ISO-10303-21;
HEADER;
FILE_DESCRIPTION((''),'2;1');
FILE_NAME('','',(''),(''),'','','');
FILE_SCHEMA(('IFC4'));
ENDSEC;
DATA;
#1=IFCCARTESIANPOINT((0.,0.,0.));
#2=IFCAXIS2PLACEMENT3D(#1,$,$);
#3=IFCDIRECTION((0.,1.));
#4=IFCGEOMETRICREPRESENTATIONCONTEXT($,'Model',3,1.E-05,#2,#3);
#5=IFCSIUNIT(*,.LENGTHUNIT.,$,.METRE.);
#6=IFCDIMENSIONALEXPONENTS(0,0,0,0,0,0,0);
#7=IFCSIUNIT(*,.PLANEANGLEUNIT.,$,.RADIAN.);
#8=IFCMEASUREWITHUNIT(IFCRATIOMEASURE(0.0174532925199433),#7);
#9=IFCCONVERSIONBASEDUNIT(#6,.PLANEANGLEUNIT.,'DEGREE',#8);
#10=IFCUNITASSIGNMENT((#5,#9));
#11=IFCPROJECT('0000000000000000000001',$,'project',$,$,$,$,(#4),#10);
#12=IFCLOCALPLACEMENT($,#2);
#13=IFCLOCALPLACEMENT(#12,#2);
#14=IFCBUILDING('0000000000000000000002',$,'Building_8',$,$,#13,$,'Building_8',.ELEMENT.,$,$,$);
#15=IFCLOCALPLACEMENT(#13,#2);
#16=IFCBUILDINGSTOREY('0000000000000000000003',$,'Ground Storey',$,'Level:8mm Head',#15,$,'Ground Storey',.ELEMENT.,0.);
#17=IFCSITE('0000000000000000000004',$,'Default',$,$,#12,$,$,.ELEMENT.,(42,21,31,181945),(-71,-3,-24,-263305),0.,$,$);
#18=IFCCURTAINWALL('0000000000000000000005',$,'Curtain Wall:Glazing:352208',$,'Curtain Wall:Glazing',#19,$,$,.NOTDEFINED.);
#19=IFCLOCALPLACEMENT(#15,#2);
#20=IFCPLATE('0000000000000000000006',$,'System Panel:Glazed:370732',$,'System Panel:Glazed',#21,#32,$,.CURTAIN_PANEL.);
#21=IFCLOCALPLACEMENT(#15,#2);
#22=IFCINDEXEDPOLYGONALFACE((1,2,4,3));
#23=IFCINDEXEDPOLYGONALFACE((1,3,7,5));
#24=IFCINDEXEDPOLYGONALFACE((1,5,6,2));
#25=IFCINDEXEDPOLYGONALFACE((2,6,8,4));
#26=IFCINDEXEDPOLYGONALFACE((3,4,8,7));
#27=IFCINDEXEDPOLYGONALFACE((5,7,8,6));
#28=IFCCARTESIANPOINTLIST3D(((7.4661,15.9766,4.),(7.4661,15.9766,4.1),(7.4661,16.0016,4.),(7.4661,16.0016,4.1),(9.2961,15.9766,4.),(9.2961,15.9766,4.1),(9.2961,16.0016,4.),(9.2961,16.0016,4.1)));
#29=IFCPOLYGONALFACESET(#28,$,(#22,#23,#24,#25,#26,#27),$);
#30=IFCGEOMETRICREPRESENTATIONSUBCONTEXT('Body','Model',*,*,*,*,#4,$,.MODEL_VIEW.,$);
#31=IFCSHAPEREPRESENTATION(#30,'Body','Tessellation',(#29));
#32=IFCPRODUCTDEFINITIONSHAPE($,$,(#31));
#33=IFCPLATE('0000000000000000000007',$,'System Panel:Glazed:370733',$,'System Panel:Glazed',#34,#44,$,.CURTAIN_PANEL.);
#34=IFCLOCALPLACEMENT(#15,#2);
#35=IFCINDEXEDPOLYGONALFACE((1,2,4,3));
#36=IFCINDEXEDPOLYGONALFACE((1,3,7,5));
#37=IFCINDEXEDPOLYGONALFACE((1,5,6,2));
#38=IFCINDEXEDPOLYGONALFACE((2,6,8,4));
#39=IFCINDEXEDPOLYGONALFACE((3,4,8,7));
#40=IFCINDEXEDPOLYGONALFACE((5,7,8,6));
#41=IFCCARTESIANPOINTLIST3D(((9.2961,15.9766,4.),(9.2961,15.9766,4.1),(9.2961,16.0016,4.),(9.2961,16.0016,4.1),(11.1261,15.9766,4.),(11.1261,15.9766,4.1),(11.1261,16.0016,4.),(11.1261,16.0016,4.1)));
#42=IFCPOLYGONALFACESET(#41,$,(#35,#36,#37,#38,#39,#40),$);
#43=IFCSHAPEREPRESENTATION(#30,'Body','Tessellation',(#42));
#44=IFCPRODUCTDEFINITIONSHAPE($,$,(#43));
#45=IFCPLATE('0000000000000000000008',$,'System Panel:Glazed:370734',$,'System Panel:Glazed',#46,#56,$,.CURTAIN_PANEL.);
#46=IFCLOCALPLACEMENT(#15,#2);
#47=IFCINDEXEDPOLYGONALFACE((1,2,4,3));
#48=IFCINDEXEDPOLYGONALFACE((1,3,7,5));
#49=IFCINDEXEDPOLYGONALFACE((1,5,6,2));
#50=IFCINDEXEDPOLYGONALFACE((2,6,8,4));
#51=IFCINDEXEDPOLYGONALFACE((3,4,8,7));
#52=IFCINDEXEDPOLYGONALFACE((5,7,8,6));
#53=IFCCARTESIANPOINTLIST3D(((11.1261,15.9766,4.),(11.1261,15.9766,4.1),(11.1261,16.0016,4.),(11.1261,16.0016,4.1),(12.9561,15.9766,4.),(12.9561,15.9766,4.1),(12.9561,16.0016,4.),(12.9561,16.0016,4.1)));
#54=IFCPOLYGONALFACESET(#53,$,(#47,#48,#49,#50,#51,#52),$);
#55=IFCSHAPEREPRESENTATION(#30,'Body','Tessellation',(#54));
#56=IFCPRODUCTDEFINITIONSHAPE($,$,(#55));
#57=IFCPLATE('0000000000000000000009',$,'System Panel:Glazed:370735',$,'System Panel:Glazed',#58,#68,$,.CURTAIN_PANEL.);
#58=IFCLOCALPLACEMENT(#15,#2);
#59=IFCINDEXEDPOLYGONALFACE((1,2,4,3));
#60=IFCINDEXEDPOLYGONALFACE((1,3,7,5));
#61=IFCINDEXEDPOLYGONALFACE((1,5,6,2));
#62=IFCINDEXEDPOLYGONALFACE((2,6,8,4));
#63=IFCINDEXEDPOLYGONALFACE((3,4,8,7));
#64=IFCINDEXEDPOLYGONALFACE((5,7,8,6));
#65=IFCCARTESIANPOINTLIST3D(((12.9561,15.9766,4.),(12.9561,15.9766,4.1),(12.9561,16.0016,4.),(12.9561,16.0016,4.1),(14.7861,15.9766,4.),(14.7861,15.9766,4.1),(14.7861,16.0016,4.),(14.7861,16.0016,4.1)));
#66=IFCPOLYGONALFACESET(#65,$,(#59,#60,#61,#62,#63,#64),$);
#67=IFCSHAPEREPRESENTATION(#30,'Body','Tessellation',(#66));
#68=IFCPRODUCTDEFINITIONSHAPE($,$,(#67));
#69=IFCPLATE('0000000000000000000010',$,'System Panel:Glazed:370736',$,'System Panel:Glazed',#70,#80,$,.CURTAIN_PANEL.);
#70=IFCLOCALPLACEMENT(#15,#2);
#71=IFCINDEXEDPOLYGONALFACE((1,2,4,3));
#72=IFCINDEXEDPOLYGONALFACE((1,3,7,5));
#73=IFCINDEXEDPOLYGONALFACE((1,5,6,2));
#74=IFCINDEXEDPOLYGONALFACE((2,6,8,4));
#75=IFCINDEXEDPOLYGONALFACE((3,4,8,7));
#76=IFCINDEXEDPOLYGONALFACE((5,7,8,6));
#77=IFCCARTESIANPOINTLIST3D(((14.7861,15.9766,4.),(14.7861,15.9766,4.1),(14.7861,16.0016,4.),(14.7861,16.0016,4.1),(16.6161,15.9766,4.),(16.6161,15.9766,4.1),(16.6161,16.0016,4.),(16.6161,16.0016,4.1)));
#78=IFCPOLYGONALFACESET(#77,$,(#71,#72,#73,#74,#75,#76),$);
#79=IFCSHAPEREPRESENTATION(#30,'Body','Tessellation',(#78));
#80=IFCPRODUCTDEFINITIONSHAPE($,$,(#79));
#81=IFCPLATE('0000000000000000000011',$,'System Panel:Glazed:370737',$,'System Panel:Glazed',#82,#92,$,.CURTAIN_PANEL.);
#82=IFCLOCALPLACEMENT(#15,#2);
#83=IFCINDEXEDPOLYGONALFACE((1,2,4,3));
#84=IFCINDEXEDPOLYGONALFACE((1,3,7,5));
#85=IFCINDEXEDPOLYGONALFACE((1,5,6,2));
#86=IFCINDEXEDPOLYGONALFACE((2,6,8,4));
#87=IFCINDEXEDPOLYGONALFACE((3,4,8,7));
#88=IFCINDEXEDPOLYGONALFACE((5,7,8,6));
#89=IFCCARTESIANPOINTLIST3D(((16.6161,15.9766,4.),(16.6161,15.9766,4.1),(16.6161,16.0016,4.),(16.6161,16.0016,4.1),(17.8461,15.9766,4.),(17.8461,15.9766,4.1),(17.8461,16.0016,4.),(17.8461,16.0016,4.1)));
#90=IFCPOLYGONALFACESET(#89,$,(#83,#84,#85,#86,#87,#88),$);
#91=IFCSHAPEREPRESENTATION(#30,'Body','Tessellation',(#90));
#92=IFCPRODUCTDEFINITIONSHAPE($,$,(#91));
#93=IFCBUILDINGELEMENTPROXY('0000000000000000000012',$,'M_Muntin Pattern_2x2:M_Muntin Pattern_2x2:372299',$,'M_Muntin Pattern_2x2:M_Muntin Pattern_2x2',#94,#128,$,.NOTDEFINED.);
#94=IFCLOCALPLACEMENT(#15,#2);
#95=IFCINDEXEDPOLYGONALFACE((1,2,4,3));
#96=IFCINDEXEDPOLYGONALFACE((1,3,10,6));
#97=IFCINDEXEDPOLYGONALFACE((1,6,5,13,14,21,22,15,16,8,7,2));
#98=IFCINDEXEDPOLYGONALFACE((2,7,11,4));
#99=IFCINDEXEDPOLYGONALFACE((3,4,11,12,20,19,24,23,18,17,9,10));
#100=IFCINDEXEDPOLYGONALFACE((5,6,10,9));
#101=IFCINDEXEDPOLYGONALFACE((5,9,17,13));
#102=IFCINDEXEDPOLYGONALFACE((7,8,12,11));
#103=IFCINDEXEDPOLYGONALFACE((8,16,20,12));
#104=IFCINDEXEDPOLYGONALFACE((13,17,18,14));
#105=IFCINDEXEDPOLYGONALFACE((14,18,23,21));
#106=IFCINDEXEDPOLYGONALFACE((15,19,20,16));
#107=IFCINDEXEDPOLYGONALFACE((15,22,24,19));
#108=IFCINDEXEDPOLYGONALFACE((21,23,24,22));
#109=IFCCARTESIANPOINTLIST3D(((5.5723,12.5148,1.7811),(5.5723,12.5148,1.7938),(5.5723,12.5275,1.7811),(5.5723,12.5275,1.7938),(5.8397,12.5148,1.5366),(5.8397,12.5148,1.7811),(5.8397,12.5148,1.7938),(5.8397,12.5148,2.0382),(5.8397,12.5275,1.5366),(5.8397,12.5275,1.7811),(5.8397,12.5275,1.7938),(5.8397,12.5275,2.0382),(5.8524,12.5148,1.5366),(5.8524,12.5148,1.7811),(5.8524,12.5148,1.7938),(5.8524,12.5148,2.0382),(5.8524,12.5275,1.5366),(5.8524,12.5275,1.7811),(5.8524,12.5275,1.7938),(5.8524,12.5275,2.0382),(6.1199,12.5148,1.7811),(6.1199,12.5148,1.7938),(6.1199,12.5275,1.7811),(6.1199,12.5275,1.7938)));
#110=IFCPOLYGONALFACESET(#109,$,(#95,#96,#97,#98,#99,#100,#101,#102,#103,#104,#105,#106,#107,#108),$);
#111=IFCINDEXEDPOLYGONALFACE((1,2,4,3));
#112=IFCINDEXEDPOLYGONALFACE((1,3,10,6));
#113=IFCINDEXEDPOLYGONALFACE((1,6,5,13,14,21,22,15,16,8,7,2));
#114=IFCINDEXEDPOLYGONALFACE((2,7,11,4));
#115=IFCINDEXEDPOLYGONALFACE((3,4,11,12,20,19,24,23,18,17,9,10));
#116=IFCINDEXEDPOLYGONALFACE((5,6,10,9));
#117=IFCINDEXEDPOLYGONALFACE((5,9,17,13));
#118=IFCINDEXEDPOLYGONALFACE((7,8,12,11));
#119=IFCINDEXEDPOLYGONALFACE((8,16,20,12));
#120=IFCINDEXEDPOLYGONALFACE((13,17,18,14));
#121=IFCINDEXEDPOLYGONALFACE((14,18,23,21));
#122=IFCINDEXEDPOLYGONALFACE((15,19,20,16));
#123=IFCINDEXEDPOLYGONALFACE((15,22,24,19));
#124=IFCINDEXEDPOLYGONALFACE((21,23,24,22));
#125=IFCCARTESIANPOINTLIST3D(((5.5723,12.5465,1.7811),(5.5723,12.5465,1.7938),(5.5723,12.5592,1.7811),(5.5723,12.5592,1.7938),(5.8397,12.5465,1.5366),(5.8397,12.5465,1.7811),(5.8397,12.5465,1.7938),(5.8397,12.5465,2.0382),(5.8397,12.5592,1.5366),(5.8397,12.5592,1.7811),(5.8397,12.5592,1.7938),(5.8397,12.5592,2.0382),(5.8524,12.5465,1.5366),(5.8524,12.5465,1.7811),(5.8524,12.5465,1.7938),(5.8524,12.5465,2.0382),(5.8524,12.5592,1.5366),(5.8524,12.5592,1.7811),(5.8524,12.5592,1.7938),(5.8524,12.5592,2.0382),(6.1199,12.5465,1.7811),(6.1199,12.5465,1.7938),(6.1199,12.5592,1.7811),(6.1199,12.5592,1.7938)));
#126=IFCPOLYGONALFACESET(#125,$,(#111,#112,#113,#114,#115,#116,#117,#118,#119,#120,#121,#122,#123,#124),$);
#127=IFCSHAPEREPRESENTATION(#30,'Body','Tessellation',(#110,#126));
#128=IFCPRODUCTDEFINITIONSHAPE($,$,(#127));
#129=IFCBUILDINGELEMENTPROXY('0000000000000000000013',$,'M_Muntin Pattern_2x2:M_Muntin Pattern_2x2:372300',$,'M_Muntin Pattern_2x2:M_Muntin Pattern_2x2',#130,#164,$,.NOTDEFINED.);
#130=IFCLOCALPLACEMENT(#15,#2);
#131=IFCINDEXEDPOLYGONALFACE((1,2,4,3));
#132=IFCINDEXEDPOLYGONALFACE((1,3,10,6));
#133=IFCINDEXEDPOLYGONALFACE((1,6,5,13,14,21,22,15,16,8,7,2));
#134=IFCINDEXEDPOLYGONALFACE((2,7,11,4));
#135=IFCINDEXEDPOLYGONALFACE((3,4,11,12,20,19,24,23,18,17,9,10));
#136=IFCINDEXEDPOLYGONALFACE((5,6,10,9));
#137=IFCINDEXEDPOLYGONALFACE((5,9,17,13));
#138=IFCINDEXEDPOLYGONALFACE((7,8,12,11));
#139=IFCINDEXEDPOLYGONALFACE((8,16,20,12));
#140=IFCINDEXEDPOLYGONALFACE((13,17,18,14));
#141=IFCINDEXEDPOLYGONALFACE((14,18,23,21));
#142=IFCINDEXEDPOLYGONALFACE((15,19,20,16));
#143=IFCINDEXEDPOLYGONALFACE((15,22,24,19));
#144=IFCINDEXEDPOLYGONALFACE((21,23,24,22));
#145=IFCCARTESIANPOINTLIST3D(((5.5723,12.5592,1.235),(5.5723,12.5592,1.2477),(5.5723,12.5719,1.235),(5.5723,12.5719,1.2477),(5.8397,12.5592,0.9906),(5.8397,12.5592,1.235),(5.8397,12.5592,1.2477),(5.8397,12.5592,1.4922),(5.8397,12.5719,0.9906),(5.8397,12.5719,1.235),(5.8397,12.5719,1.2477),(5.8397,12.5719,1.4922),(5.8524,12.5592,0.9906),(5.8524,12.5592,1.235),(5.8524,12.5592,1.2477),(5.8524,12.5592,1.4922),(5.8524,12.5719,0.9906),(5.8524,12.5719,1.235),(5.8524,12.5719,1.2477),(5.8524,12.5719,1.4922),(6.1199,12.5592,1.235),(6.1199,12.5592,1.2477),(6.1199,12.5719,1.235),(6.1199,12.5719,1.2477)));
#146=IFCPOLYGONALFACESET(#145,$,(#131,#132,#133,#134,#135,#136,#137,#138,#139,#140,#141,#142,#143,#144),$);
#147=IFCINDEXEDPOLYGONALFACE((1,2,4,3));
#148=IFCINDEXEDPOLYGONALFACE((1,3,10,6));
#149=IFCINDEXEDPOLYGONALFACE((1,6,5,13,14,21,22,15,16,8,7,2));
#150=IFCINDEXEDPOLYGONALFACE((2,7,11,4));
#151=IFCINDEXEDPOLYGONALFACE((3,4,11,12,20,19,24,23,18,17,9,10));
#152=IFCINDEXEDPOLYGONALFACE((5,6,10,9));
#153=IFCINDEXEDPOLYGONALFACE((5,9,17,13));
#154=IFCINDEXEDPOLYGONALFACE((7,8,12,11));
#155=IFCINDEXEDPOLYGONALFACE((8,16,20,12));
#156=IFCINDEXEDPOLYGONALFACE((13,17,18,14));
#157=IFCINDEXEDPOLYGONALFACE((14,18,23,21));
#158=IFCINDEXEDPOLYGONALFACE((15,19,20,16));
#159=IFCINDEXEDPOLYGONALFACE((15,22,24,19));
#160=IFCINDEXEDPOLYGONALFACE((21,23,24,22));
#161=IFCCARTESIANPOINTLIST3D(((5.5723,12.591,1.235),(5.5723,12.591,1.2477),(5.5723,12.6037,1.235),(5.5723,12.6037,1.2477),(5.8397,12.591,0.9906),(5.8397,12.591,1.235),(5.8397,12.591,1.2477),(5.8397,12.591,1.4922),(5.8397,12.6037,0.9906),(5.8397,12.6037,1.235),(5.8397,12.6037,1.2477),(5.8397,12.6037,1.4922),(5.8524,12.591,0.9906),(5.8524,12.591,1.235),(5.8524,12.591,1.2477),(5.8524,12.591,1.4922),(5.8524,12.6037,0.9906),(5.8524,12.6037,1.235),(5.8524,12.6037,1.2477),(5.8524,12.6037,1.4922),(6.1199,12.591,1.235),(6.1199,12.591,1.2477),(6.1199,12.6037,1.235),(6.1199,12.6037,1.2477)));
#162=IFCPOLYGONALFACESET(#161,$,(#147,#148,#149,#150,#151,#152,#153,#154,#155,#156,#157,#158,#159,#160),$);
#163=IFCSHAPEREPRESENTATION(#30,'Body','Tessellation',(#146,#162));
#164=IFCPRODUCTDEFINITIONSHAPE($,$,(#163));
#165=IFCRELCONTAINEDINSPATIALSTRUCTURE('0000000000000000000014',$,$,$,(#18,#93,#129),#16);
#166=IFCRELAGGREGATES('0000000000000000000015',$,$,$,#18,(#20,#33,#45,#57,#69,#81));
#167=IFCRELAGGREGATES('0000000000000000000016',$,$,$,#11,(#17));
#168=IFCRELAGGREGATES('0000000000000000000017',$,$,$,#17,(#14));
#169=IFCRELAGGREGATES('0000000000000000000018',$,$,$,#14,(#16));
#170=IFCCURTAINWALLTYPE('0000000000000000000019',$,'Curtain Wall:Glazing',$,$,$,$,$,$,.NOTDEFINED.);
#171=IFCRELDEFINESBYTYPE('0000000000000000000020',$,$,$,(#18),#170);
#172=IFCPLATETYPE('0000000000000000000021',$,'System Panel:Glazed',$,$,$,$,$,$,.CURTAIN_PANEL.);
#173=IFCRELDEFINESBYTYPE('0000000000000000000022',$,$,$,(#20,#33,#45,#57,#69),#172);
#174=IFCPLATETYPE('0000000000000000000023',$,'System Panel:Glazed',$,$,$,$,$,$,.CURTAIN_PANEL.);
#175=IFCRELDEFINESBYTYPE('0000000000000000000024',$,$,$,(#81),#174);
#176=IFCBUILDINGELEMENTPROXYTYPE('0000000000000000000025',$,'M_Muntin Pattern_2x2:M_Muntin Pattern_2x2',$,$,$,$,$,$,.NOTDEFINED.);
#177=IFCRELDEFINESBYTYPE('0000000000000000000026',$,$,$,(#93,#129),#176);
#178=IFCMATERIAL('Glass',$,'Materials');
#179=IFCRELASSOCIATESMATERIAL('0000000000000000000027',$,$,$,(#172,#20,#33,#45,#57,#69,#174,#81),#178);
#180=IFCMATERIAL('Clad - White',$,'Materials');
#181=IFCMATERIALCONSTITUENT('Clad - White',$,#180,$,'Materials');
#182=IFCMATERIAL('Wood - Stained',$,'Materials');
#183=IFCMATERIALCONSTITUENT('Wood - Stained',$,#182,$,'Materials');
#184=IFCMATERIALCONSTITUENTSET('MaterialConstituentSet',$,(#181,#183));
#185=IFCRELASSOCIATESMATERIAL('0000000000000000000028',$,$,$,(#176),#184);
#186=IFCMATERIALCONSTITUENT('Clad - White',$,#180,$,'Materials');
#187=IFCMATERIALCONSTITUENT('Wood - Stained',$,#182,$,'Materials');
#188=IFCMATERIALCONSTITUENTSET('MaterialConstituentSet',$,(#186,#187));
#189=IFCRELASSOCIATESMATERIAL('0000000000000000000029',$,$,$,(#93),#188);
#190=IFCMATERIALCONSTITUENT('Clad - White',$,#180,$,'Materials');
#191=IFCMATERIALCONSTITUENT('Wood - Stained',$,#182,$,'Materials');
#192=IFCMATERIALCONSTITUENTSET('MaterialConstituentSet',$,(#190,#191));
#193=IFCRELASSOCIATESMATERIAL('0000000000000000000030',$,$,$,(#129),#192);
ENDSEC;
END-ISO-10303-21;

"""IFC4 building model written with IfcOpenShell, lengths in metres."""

from ifc_helpers import new_model, entity, si_unit, converted_unit, direction, frame, origin, place, context, subcontext, project, spatial, indexed_curve, outline, extrude, source, transform, mapped, material, constituent, constituent_set, type_object, type_shapes, element, aggregate, save


model = new_model("IFC4")

# Units and contexts
model_context = context("Model", 3, precision=1e-05, world=origin(), true_north=direction((0.0, 1.0)))
body_context = subcontext(model_context, "Body", "Model", "MODEL_VIEW")
ifc_project = project(units=[si_unit("LENGTHUNIT", "METRE"), converted_unit("PLANEANGLEUNIT", "DEGREE", entity("IfcRatioMeasure", 0.0174532925199433), si_unit("PLANEANGLEUNIT", "RADIAN"), dimensions=[0, 0, 0, 0, 0, 0, 0])], contexts=[model_context])

# Site, building, storey
site_placement = place(None, origin())
site = spatial("IfcSite", under=ifc_project, at=site_placement, Name="Default", CompositionType="ELEMENT", RefLatitude=(42, 21, 31, 181945), RefLongitude=(-71, -3, -24, -263305), RefElevation=0.0)
building_placement = place(site_placement, origin())
building = spatial("IfcBuilding", under=site, at=building_placement, Name="Building_8", LongName="Building_8", CompositionType="ELEMENT")
storey_placement = place(building_placement, origin())
storey = spatial("IfcBuildingStorey", under=building, at=storey_placement, Name="Ground Storey", ObjectType="Level:8mm Head", LongName="Ground Storey", CompositionType="ELEMENT", Elevation=0.0)

# Curtain wall, plates
curtain_wall_type = type_object("IfcCurtainWallType", Name="Curtain Wall:Glazing", PredefinedType="NOTDEFINED")
curtain_wall_placement = place(storey_placement, origin())
curtain_wall = element("IfcCurtainWall", 1, at=curtain_wall_placement, inside=storey, type_object=curtain_wall_type, Name="Curtain Wall:Glazing:352208", ObjectType="Curtain Wall:Glazing", PredefinedType="NOTDEFINED")
ifc_material_1 = material(Name="Glass", Category="Materials")
plate_type_1 = type_object("IfcPlateType", Name="System Panel:Glazed", PredefinedType="CURTAIN_PANEL", material=ifc_material_1)
shared_shape_1 = source(origin(), body_context, "Body", "SweptSolid", [
    extrude(outline(indexed_curve([(-0.0125, -0.915), (0.0125, -0.915), (0.0125, 0.915), (-0.0125, 0.915), (-0.0125, -0.915)], self_intersect=False)), frame((0.0, 0.037, 0.0), z_axis=(0.0, 0.0, 1.0), x_axis=(0.0, 1.0, 0.0)), (0.0, 0.0, 1.0), 0.1),
])
type_shapes(plate_type_1, [shared_shape_1])
plate_1_placement = place(curtain_wall_placement, frame((8.3811, 15.9521, 4.0)))
plate_1 = element("IfcPlate", 2, at=plate_1_placement, type_object=plate_type_1, material=ifc_material_1, Name="System Panel:Glazed:370732", ObjectType="System Panel:Glazed", PredefinedType="CURTAIN_PANEL", context=body_context, shape_type="MappedRepresentation", body=[
    mapped(shared_shape_1, transform((0.0, 0.0, 0.0), scale=1.0)),
])
plate_2_placement = place(curtain_wall_placement, frame((10.2111, 15.9521, 4.0)))
plate_2 = element("IfcPlate", 3, at=plate_2_placement, type_object=plate_type_1, material=ifc_material_1, Name="System Panel:Glazed:370733", ObjectType="System Panel:Glazed", PredefinedType="CURTAIN_PANEL", context=body_context, shape_type="MappedRepresentation", body=[
    mapped(shared_shape_1, transform((0.0, 0.0, 0.0), scale=1.0)),
])
plate_3_placement = place(curtain_wall_placement, frame((12.0411, 15.9521, 4.0)))
plate_3 = element("IfcPlate", 4, at=plate_3_placement, type_object=plate_type_1, material=ifc_material_1, Name="System Panel:Glazed:370734", ObjectType="System Panel:Glazed", PredefinedType="CURTAIN_PANEL", context=body_context, shape_type="MappedRepresentation", body=[
    mapped(shared_shape_1, transform((0.0, 0.0, 0.0), scale=1.0)),
])
plate_4_placement = place(curtain_wall_placement, frame((13.8711, 15.9521, 4.0)))
plate_4 = element("IfcPlate", 5, at=plate_4_placement, type_object=plate_type_1, material=ifc_material_1, Name="System Panel:Glazed:370735", ObjectType="System Panel:Glazed", PredefinedType="CURTAIN_PANEL", context=body_context, shape_type="MappedRepresentation", body=[
    mapped(shared_shape_1, transform((0.0, 0.0, 0.0), scale=1.0)),
])
plate_5_placement = place(curtain_wall_placement, frame((15.7011, 15.9521, 4.0)))
plate_5 = element("IfcPlate", 6, at=plate_5_placement, type_object=plate_type_1, material=ifc_material_1, Name="System Panel:Glazed:370736", ObjectType="System Panel:Glazed", PredefinedType="CURTAIN_PANEL", context=body_context, shape_type="MappedRepresentation", body=[
    mapped(shared_shape_1, transform((0.0, 0.0, 0.0), scale=1.0)),
])
plate_type_2 = type_object("IfcPlateType", Name="System Panel:Glazed", PredefinedType="CURTAIN_PANEL", material=ifc_material_1)
shared_shape_2 = source(origin(), body_context, "Body", "SweptSolid", [
    extrude(outline(indexed_curve([(-0.0125, -0.615), (0.0125, -0.615), (0.0125, 0.615), (-0.0125, 0.615), (-0.0125, -0.615)], self_intersect=False)), frame((0.0, 0.037, 0.0), z_axis=(0.0, 0.0, 1.0), x_axis=(0.0, 1.0, 0.0)), (0.0, 0.0, 1.0), 0.1),
])
type_shapes(plate_type_2, [shared_shape_2])
plate_6_placement = place(curtain_wall_placement, frame((17.2311, 15.9521, 4.0)))
plate_6 = element("IfcPlate", 7, at=plate_6_placement, type_object=plate_type_2, material=ifc_material_1, Name="System Panel:Glazed:370737", ObjectType="System Panel:Glazed", PredefinedType="CURTAIN_PANEL", context=body_context, shape_type="MappedRepresentation", body=[
    mapped(shared_shape_2, transform((0.0, 0.0, 0.0), scale=1.0)),
])
aggregate(curtain_wall, [plate_1, plate_2, plate_3, plate_4, plate_5, plate_6])

# Building element proxies
ifc_material_2 = material(Name="Clad - White", Category="Materials")
ifc_constituent_1 = constituent(ifc_material_2, Name="Clad - White", Category="Materials")
ifc_material_3 = material(Name="Wood - Stained", Category="Materials")
ifc_constituent_2 = constituent(ifc_material_3, Name="Wood - Stained", Category="Materials")
ifc_constituent_set_1 = constituent_set(constituents=[ifc_constituent_1, ifc_constituent_2], Name="MaterialConstituentSet")
ifc_constituent_3 = constituent(ifc_material_2, Name="Clad - White", Category="Materials")
ifc_constituent_4 = constituent(ifc_material_3, Name="Wood - Stained", Category="Materials")
ifc_constituent_set_2 = constituent_set(constituents=[ifc_constituent_3, ifc_constituent_4], Name="MaterialConstituentSet")
building_element_proxy_type_1 = type_object("IfcBuildingElementProxyType", Name="M_Muntin Pattern_2x2:M_Muntin Pattern_2x2", PredefinedType="NOTDEFINED", material=ifc_constituent_set_2)
shared_shape_3 = source(origin(), body_context, "Body", "SweptSolid", [
    extrude(outline(indexed_curve([(0.0064, -0.0064), (0.2508, -0.0064), (0.2508, 0.0063), (0.0064, 0.0063), (0.0064, 0.2738), (-0.0063, 0.2738), (-0.0063, 0.0063), (-0.2508, 0.0063), (-0.2508, -0.0064), (-0.0063, -0.0064), (-0.0063, -0.2738), (0.0064, -0.2738), (0.0064, -0.0064)], self_intersect=False)), frame((0.0, -0.0222, 0.2508), z_axis=(0.0, 1.0, 0.0), x_axis=(0.0, 0.0, 1.0)), (0.0, 0.0, 1.0), 0.0127),
    extrude(outline(indexed_curve([(0.0064, -0.0064), (0.2508, -0.0064), (0.2508, 0.0063), (0.0064, 0.0063), (0.0064, 0.2738), (-0.0063, 0.2738), (-0.0063, 0.0063), (-0.2508, 0.0063), (-0.2508, -0.0064), (-0.0063, -0.0064), (-0.0063, -0.2738), (0.0064, -0.2738), (0.0064, -0.0064)], self_intersect=False)), frame((0.0, 0.0095, 0.2508), z_axis=(0.0, 1.0, 0.0), x_axis=(0.0, 0.0, 1.0)), (0.0, 0.0, 1.0), 0.0127),
])
type_shapes(building_element_proxy_type_1, [shared_shape_3])
proxy_1_placement = place(storey_placement, frame((5.8461, 12.537, 1.5366)))
element("IfcBuildingElementProxy", 8, at=proxy_1_placement, inside=storey, type_object=building_element_proxy_type_1, material=ifc_constituent_set_1, Name="M_Muntin Pattern_2x2:M_Muntin Pattern_2x2:372299", ObjectType="M_Muntin Pattern_2x2:M_Muntin Pattern_2x2", PredefinedType="NOTDEFINED", context=body_context, shape_type="MappedRepresentation", body=[
    mapped(shared_shape_3, transform((0.0, 0.0, 0.0), scale=1.0)),
])
ifc_constituent_5 = constituent(ifc_material_2, Name="Clad - White", Category="Materials")
ifc_constituent_6 = constituent(ifc_material_3, Name="Wood - Stained", Category="Materials")
ifc_constituent_set_3 = constituent_set(constituents=[ifc_constituent_5, ifc_constituent_6], Name="MaterialConstituentSet")
proxy_2_placement = place(storey_placement, frame((5.8461, 12.5814, 0.9906)))
element("IfcBuildingElementProxy", 9, at=proxy_2_placement, inside=storey, type_object=building_element_proxy_type_1, material=ifc_constituent_set_3, Name="M_Muntin Pattern_2x2:M_Muntin Pattern_2x2:372300", ObjectType="M_Muntin Pattern_2x2:M_Muntin Pattern_2x2", PredefinedType="NOTDEFINED", context=body_context, shape_type="MappedRepresentation", body=[
    mapped(shared_shape_3, transform((0.0, 0.0, 0.0), scale=1.0)),
])

save(model, "model.ifc")
